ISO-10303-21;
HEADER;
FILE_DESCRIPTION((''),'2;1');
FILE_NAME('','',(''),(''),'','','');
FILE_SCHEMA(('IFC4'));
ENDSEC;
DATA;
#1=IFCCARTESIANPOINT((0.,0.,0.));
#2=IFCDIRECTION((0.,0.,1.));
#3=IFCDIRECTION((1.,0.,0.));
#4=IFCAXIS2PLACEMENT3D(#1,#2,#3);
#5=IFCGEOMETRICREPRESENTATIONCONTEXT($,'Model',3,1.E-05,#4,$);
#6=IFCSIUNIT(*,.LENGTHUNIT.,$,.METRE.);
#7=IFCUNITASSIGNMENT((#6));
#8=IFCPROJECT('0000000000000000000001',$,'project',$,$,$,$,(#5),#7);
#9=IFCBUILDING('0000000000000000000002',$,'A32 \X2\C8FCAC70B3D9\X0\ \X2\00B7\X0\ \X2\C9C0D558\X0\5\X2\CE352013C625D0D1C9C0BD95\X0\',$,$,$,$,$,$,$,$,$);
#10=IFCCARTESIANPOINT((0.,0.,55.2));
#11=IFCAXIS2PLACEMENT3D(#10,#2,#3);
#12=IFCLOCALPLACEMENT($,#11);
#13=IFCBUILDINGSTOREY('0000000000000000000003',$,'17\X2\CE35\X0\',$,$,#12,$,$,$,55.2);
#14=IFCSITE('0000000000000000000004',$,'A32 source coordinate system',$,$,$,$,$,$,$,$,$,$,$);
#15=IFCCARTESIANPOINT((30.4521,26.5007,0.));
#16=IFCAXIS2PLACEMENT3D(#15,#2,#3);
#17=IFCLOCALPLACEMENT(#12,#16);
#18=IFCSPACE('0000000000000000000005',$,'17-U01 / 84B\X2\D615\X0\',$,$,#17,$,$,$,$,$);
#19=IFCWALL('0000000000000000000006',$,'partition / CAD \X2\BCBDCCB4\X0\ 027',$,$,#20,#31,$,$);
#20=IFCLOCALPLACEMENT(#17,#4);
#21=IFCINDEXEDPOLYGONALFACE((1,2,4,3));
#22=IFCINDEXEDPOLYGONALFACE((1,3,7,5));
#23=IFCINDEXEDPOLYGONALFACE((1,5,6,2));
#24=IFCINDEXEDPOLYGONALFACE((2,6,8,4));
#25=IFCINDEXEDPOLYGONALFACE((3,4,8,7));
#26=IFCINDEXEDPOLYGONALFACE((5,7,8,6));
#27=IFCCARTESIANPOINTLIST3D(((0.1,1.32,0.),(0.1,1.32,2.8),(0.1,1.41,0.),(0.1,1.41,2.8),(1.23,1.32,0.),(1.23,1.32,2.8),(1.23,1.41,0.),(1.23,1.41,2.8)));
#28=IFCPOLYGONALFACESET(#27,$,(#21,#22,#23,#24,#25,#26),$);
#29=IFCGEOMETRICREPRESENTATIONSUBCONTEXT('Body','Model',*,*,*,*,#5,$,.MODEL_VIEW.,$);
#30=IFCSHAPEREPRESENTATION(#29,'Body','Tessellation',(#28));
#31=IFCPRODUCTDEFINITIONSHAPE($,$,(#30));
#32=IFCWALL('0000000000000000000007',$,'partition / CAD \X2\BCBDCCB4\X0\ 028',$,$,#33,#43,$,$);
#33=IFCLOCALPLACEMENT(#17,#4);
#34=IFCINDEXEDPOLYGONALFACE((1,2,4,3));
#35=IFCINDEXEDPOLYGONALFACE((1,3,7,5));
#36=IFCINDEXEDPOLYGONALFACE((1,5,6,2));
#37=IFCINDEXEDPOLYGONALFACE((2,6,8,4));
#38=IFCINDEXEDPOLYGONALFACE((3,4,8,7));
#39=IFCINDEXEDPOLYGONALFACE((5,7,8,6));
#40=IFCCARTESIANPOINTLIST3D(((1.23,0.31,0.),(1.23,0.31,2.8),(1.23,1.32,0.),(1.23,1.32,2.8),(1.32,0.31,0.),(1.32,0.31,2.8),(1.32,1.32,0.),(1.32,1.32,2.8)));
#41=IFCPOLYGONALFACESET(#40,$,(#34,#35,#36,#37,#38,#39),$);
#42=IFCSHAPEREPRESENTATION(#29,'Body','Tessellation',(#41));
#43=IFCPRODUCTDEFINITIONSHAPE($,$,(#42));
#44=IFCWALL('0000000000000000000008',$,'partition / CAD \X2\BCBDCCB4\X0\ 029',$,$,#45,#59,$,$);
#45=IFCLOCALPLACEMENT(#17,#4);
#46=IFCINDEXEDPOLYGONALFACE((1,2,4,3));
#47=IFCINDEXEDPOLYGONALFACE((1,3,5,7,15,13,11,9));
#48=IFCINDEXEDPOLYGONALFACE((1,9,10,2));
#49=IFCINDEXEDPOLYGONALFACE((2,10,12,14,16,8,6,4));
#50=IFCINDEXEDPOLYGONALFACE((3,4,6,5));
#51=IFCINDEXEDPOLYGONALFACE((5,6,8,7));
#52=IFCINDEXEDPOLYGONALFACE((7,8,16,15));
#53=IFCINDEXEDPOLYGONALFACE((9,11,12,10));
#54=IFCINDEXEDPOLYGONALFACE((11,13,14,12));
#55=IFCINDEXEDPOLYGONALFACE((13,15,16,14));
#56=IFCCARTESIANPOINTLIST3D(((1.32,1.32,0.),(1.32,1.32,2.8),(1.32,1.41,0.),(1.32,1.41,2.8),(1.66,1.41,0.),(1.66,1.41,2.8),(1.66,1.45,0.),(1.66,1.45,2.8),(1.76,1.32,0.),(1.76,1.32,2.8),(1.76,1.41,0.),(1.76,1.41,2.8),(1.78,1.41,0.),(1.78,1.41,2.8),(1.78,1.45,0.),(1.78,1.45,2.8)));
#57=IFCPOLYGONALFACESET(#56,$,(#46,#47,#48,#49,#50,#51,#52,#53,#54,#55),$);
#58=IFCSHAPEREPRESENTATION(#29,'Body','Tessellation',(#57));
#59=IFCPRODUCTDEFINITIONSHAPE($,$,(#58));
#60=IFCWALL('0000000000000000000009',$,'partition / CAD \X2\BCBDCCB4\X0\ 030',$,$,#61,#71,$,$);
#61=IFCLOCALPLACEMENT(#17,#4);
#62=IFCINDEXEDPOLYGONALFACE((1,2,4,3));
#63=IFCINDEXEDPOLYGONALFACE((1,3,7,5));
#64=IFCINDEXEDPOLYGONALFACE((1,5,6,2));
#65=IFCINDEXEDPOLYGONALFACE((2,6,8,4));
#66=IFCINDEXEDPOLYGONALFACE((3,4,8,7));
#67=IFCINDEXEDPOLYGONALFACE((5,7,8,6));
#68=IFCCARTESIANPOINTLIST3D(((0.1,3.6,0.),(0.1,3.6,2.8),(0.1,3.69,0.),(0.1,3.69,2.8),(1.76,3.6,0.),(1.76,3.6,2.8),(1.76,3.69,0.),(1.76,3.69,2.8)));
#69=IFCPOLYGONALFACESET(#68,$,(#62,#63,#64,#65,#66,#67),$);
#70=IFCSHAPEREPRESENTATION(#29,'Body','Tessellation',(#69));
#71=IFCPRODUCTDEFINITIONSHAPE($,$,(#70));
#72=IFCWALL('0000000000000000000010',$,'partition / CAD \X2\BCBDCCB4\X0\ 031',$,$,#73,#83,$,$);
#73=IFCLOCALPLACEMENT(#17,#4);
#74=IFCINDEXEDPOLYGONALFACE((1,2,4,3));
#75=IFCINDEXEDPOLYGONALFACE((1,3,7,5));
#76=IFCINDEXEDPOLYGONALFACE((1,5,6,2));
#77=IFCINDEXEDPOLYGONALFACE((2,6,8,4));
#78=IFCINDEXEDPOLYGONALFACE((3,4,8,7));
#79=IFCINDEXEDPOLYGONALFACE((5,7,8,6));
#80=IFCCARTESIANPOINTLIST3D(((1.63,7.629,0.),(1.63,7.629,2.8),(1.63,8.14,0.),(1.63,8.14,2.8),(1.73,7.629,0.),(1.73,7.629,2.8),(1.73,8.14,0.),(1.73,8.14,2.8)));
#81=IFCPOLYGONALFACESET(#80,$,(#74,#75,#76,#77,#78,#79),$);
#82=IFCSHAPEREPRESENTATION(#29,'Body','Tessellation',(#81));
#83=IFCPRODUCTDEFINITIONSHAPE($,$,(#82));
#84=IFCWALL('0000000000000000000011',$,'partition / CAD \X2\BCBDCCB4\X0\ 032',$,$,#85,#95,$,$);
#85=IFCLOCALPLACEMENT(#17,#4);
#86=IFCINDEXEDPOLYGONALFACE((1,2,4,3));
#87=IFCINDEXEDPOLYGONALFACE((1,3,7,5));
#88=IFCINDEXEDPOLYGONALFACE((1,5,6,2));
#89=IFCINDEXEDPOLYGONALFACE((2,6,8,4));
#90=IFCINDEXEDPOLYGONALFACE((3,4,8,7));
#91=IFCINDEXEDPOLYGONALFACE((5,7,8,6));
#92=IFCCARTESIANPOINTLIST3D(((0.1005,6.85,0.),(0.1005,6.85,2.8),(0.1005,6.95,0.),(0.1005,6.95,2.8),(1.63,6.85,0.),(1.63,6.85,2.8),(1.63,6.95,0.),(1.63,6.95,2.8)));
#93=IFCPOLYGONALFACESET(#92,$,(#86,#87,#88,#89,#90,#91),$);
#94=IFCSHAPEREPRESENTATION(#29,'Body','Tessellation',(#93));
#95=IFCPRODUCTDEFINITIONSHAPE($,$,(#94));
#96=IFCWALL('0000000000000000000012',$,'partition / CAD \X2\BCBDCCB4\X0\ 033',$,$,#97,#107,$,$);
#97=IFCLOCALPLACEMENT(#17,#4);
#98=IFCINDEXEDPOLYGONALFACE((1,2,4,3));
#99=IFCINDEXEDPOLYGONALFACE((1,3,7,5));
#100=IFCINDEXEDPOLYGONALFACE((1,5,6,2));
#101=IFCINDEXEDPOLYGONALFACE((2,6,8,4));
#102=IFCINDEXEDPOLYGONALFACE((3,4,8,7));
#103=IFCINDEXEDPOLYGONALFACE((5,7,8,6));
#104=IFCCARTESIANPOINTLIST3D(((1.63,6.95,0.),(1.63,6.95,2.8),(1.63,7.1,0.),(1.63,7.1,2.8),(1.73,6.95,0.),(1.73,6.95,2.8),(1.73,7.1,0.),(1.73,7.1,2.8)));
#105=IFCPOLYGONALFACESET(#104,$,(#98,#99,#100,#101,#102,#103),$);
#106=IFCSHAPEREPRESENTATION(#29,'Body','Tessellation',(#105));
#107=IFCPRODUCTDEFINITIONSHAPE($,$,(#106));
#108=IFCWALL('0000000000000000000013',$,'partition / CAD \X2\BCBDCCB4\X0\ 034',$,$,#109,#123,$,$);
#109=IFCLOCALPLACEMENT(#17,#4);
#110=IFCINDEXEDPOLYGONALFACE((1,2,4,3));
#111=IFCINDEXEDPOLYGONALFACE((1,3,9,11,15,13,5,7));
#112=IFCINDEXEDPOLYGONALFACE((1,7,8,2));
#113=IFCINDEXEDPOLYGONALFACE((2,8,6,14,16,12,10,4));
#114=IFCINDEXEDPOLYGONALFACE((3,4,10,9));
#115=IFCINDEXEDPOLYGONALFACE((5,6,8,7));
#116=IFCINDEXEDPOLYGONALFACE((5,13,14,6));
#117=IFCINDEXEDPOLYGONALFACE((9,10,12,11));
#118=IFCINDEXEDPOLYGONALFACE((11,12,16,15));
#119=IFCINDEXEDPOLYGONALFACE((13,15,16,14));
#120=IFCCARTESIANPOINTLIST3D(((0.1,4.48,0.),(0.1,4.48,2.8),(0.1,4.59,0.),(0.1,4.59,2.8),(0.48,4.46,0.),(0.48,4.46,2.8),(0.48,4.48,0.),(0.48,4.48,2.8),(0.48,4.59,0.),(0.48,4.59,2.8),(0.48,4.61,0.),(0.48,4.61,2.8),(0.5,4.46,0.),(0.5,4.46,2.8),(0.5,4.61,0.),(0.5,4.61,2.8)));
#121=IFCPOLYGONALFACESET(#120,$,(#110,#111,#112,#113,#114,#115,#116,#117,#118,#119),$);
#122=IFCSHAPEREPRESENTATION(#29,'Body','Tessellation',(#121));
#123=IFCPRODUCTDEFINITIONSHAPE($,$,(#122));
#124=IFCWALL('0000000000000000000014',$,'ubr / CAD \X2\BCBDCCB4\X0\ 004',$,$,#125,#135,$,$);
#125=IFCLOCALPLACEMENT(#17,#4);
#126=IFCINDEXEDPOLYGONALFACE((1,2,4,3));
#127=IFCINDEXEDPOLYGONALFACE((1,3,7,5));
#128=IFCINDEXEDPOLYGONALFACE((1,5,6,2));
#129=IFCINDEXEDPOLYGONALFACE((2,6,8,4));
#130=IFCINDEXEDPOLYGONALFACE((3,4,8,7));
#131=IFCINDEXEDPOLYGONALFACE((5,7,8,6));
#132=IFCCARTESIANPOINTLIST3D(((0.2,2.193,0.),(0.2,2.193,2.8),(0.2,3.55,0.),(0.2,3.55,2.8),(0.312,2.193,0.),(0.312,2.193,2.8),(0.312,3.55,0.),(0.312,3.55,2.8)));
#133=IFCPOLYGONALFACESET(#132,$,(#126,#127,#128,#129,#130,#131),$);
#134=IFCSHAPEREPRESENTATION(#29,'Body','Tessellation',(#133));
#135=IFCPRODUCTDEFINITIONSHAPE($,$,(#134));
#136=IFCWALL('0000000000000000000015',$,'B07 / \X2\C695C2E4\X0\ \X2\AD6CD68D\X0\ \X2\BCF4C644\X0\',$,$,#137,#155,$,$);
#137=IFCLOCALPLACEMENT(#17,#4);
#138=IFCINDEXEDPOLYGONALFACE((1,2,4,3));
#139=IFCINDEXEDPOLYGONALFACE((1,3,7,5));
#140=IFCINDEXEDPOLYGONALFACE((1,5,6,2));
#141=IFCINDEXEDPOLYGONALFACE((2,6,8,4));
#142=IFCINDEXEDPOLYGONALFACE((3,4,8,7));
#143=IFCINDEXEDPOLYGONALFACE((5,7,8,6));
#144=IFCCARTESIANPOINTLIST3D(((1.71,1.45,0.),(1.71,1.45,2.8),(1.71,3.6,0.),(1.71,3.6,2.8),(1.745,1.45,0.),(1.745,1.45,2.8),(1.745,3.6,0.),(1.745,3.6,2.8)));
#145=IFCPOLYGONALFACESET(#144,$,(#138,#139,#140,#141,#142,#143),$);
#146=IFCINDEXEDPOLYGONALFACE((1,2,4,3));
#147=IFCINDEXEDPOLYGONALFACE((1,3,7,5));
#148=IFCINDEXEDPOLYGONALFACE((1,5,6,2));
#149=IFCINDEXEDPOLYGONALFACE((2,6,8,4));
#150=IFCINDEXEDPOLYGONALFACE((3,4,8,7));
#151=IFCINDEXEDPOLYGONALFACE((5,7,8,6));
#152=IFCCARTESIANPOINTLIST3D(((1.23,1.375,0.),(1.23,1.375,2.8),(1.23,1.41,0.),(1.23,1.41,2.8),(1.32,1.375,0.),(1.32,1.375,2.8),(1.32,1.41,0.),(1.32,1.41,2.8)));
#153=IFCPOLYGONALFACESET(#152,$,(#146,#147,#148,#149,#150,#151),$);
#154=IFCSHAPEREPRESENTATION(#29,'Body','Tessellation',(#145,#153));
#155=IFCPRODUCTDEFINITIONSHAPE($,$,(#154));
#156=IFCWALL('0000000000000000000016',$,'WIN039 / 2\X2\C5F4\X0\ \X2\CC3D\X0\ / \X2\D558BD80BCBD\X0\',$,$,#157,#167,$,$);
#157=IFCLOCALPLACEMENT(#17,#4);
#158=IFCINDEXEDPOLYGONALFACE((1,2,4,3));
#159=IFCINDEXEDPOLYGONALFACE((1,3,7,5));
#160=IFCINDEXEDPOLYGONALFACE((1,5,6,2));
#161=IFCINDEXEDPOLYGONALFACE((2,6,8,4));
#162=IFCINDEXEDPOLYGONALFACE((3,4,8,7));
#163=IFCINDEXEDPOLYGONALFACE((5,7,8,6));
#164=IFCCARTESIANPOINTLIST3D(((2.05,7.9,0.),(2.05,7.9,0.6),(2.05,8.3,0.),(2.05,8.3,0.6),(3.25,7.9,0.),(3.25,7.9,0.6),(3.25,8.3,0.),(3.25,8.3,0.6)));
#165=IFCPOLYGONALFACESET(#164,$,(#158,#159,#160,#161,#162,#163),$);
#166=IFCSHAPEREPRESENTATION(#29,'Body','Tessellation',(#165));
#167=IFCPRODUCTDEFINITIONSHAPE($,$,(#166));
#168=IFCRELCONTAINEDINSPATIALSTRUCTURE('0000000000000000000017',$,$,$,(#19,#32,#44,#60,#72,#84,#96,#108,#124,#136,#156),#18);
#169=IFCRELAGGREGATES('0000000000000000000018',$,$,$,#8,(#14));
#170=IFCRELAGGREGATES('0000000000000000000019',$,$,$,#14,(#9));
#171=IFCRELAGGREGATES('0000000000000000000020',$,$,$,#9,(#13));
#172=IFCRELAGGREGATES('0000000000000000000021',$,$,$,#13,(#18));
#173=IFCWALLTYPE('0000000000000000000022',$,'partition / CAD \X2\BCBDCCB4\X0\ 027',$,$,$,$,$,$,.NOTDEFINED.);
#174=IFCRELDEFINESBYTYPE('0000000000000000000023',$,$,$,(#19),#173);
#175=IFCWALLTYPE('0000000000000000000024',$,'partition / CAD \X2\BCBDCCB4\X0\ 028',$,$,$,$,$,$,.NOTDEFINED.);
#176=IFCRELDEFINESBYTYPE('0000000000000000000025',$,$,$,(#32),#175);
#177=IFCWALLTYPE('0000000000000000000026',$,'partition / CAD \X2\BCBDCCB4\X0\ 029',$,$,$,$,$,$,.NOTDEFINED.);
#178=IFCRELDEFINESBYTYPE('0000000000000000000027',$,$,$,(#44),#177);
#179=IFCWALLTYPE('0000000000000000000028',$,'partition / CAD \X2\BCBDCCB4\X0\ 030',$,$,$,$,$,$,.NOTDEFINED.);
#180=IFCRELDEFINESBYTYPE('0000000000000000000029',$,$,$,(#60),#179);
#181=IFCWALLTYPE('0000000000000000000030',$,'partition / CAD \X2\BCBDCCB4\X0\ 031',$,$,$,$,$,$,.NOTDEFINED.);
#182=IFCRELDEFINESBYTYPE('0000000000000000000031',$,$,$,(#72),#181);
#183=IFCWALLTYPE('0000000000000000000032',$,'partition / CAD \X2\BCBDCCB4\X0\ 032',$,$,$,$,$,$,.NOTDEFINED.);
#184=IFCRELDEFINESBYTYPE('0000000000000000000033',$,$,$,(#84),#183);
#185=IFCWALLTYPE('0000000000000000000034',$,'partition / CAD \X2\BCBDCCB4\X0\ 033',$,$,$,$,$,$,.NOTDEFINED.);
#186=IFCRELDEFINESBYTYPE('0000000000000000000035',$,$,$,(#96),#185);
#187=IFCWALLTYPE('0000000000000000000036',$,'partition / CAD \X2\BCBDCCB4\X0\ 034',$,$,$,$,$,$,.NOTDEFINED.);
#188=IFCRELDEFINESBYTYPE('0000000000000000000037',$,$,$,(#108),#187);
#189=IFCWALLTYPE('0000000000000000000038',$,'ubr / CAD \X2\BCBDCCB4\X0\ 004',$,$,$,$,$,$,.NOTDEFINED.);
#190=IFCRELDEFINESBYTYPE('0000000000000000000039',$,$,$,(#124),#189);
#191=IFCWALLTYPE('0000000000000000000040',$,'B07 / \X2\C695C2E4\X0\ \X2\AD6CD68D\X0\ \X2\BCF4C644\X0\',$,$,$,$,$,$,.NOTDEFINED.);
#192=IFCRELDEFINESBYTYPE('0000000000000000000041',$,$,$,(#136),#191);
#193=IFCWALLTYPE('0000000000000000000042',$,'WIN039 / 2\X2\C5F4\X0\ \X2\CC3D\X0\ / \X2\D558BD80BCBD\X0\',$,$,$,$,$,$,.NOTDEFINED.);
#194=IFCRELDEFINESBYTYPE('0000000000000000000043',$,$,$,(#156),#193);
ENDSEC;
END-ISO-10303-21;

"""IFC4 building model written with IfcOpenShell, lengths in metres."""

from ifc_helpers import new_model, si_unit, frame, origin, origin_with_axes, place, context, subcontext, project, spatial, polyline, outline, extrude, source, transform, mapped, type_object, type_shapes, element, save


model = new_model("IFC4")

# Units and contexts
model_context = context("Model", 3, precision=1e-05, world=origin_with_axes())
body_context = subcontext(model_context, "Body", "Model", "MODEL_VIEW")
ifc_project = project(units=[si_unit("LENGTHUNIT", "METRE")], contexts=[model_context])

# Site, building, storey, space
site = spatial("IfcSite", under=ifc_project, Name="A32 source coordinate system")
building = spatial("IfcBuilding", under=site, Name="A32 주거동 · 지하5층–옥탑지붕")
storey_placement = place(None, frame((0.0, 0.0, 55.2), z_axis=(0.0, 0.0, 1.0), x_axis=(1.0, 0.0, 0.0)))
storey = spatial("IfcBuildingStorey", under=building, at=storey_placement, Name="17층", Elevation=55.2)
space_placement = place(storey_placement, frame((30.4521, 26.5007, 0.0), z_axis=(0.0, 0.0, 1.0), x_axis=(1.0, 0.0, 0.0)))
space = spatial("IfcSpace", under=storey, at=space_placement, Name="17-U01 / 84B형")

# Walls
wall_type_1 = type_object("IfcWallType", Name="partition / CAD 벽체 027", PredefinedType="NOTDEFINED")
shared_shape_1 = source(origin(), body_context, "Body", "SweptSolid", [
    extrude(outline(polyline([(0.1, 1.32), (0.1, 1.41), (1.23, 1.41), (1.23, 1.32), (0.1, 1.32)])), origin(), (0.0, 0.0, 1.0), 2.8),
])
type_shapes(wall_type_1, [shared_shape_1])
wall_1_placement = place(space_placement, origin_with_axes())
element("IfcWall", 1, at=wall_1_placement, inside=space, type_object=wall_type_1, Name="partition / CAD 벽체 027", context=body_context, shape_type="MappedRepresentation", body=[
    mapped(shared_shape_1, transform((0.0, 0.0, 0.0), scale=1.0)),
])
wall_type_2 = type_object("IfcWallType", Name="partition / CAD 벽체 028", PredefinedType="NOTDEFINED")
shared_shape_2 = source(origin(), body_context, "Body", "SweptSolid", [
    extrude(outline(polyline([(1.32, 0.31), (1.23, 0.31), (1.23, 1.32), (1.32, 1.32), (1.32, 0.31)])), origin(), (0.0, 0.0, 1.0), 2.8),
])
type_shapes(wall_type_2, [shared_shape_2])
wall_2_placement = place(space_placement, origin_with_axes())
element("IfcWall", 2, at=wall_2_placement, inside=space, type_object=wall_type_2, Name="partition / CAD 벽체 028", context=body_context, shape_type="MappedRepresentation", body=[
    mapped(shared_shape_2, transform((0.0, 0.0, 0.0), scale=1.0)),
])
wall_type_3 = type_object("IfcWallType", Name="partition / CAD 벽체 029", PredefinedType="NOTDEFINED")
shared_shape_3 = source(origin(), body_context, "Body", "SweptSolid", [
    extrude(outline(polyline([(1.66, 1.41), (1.66, 1.45), (1.78, 1.45), (1.78, 1.41), (1.76, 1.41), (1.76, 1.32), (1.32, 1.32), (1.32, 1.41), (1.66, 1.41)])), origin(), (0.0, 0.0, 1.0), 2.8),
])
type_shapes(wall_type_3, [shared_shape_3])
wall_3_placement = place(space_placement, origin_with_axes())
element("IfcWall", 3, at=wall_3_placement, inside=space, type_object=wall_type_3, Name="partition / CAD 벽체 029", context=body_context, shape_type="MappedRepresentation", body=[
    mapped(shared_shape_3, transform((0.0, 0.0, 0.0), scale=1.0)),
])
wall_type_4 = type_object("IfcWallType", Name="partition / CAD 벽체 030", PredefinedType="NOTDEFINED")
shared_shape_4 = source(origin(), body_context, "Body", "SweptSolid", [
    extrude(outline(polyline([(1.76, 3.69), (1.76, 3.6), (0.1, 3.6), (0.1, 3.69), (1.76, 3.69)])), origin(), (0.0, 0.0, 1.0), 2.8),
])
type_shapes(wall_type_4, [shared_shape_4])
wall_4_placement = place(space_placement, origin_with_axes())
element("IfcWall", 4, at=wall_4_placement, inside=space, type_object=wall_type_4, Name="partition / CAD 벽체 030", context=body_context, shape_type="MappedRepresentation", body=[
    mapped(shared_shape_4, transform((0.0, 0.0, 0.0), scale=1.0)),
])
wall_type_5 = type_object("IfcWallType", Name="partition / CAD 벽체 031", PredefinedType="NOTDEFINED")
shared_shape_5 = source(origin(), body_context, "Body", "SweptSolid", [
    extrude(outline(polyline([(1.63, 8.14), (1.73, 8.14), (1.73, 7.629), (1.63, 7.629), (1.63, 8.14)])), origin(), (0.0, 0.0, 1.0), 2.8),
])
type_shapes(wall_type_5, [shared_shape_5])
wall_5_placement = place(space_placement, origin_with_axes())
element("IfcWall", 5, at=wall_5_placement, inside=space, type_object=wall_type_5, Name="partition / CAD 벽체 031", context=body_context, shape_type="MappedRepresentation", body=[
    mapped(shared_shape_5, transform((0.0, 0.0, 0.0), scale=1.0)),
])
wall_type_6 = type_object("IfcWallType", Name="partition / CAD 벽체 032", PredefinedType="NOTDEFINED")
shared_shape_6 = source(origin(), body_context, "Body", "SweptSolid", [
    extrude(outline(polyline([(0.1005, 6.95), (1.63, 6.95), (1.63, 6.85), (0.1005, 6.85), (0.1005, 6.95)])), origin(), (0.0, 0.0, 1.0), 2.8),
])
type_shapes(wall_type_6, [shared_shape_6])
wall_6_placement = place(space_placement, origin_with_axes())
element("IfcWall", 6, at=wall_6_placement, inside=space, type_object=wall_type_6, Name="partition / CAD 벽체 032", context=body_context, shape_type="MappedRepresentation", body=[
    mapped(shared_shape_6, transform((0.0, 0.0, 0.0), scale=1.0)),
])
wall_type_7 = type_object("IfcWallType", Name="partition / CAD 벽체 033", PredefinedType="NOTDEFINED")
shared_shape_7 = source(origin(), body_context, "Body", "SweptSolid", [
    extrude(outline(polyline([(1.63, 7.1), (1.73, 7.1), (1.73, 6.95), (1.63, 6.95), (1.63, 7.1)])), origin(), (0.0, 0.0, 1.0), 2.8),
])
type_shapes(wall_type_7, [shared_shape_7])
wall_7_placement = place(space_placement, origin_with_axes())
element("IfcWall", 7, at=wall_7_placement, inside=space, type_object=wall_type_7, Name="partition / CAD 벽체 033", context=body_context, shape_type="MappedRepresentation", body=[
    mapped(shared_shape_7, transform((0.0, 0.0, 0.0), scale=1.0)),
])
wall_type_8 = type_object("IfcWallType", Name="partition / CAD 벽체 034", PredefinedType="NOTDEFINED")
shared_shape_8 = source(origin(), body_context, "Body", "SweptSolid", [
    extrude(outline(polyline([(0.48, 4.61), (0.5, 4.61), (0.5, 4.46), (0.48, 4.46), (0.48, 4.48), (0.1, 4.48), (0.1, 4.59), (0.48, 4.59), (0.48, 4.61)])), origin(), (0.0, 0.0, 1.0), 2.8),
])
type_shapes(wall_type_8, [shared_shape_8])
wall_8_placement = place(space_placement, origin_with_axes())
element("IfcWall", 8, at=wall_8_placement, inside=space, type_object=wall_type_8, Name="partition / CAD 벽체 034", context=body_context, shape_type="MappedRepresentation", body=[
    mapped(shared_shape_8, transform((0.0, 0.0, 0.0), scale=1.0)),
])
wall_type_9 = type_object("IfcWallType", Name="ubr / CAD 벽체 004", PredefinedType="NOTDEFINED")
shared_shape_9 = source(origin(), body_context, "Body", "SweptSolid", [
    extrude(outline(polyline([(0.312, 2.193), (0.2, 2.193), (0.2, 3.55), (0.312, 3.55), (0.312, 2.193)])), origin(), (0.0, 0.0, 1.0), 2.8),
])
type_shapes(wall_type_9, [shared_shape_9])
wall_9_placement = place(space_placement, origin_with_axes())
element("IfcWall", 9, at=wall_9_placement, inside=space, type_object=wall_type_9, Name="ubr / CAD 벽체 004", context=body_context, shape_type="MappedRepresentation", body=[
    mapped(shared_shape_9, transform((0.0, 0.0, 0.0), scale=1.0)),
])
wall_type_10 = type_object("IfcWallType", Name="B07 / 욕실 구획 보완", PredefinedType="NOTDEFINED")
shared_shape_10 = source(origin(), body_context, "Body", "SweptSolid", [
    extrude(outline(polyline([(1.71, 1.45), (1.71, 3.6), (1.745, 3.6), (1.745, 1.45), (1.71, 1.45)])), origin(), (0.0, 0.0, 1.0), 2.8),
    extrude(outline(polyline([(1.32, 1.41), (1.32, 1.375), (1.23, 1.375), (1.23, 1.41), (1.32, 1.41)])), origin(), (0.0, 0.0, 1.0), 2.8),
])
type_shapes(wall_type_10, [shared_shape_10])
wall_10_placement = place(space_placement, origin_with_axes())
element("IfcWall", 10, at=wall_10_placement, inside=space, type_object=wall_type_10, Name="B07 / 욕실 구획 보완", context=body_context, shape_type="MappedRepresentation", body=[
    mapped(shared_shape_10, transform((0.0, 0.0, 0.0), scale=1.0)),
])
wall_type_11 = type_object("IfcWallType", Name="WIN039 / 2열 창 / 하부벽", PredefinedType="NOTDEFINED")
shared_shape_11 = source(origin(), body_context, "Body", "SweptSolid", [
    extrude(outline(polyline([(2.05, 8.3), (3.25, 8.3), (3.25, 7.9), (2.05, 7.9), (2.05, 8.3)])), origin(), (0.0, 0.0, 1.0), 0.6),
])
type_shapes(wall_type_11, [shared_shape_11])
wall_11_placement = place(space_placement, origin_with_axes())
element("IfcWall", 11, at=wall_11_placement, inside=space, type_object=wall_type_11, Name="WIN039 / 2열 창 / 하부벽", context=body_context, shape_type="MappedRepresentation", body=[
    mapped(shared_shape_11, transform((0.0, 0.0, 0.0), scale=1.0)),
])

save(model, "model.ifc")
